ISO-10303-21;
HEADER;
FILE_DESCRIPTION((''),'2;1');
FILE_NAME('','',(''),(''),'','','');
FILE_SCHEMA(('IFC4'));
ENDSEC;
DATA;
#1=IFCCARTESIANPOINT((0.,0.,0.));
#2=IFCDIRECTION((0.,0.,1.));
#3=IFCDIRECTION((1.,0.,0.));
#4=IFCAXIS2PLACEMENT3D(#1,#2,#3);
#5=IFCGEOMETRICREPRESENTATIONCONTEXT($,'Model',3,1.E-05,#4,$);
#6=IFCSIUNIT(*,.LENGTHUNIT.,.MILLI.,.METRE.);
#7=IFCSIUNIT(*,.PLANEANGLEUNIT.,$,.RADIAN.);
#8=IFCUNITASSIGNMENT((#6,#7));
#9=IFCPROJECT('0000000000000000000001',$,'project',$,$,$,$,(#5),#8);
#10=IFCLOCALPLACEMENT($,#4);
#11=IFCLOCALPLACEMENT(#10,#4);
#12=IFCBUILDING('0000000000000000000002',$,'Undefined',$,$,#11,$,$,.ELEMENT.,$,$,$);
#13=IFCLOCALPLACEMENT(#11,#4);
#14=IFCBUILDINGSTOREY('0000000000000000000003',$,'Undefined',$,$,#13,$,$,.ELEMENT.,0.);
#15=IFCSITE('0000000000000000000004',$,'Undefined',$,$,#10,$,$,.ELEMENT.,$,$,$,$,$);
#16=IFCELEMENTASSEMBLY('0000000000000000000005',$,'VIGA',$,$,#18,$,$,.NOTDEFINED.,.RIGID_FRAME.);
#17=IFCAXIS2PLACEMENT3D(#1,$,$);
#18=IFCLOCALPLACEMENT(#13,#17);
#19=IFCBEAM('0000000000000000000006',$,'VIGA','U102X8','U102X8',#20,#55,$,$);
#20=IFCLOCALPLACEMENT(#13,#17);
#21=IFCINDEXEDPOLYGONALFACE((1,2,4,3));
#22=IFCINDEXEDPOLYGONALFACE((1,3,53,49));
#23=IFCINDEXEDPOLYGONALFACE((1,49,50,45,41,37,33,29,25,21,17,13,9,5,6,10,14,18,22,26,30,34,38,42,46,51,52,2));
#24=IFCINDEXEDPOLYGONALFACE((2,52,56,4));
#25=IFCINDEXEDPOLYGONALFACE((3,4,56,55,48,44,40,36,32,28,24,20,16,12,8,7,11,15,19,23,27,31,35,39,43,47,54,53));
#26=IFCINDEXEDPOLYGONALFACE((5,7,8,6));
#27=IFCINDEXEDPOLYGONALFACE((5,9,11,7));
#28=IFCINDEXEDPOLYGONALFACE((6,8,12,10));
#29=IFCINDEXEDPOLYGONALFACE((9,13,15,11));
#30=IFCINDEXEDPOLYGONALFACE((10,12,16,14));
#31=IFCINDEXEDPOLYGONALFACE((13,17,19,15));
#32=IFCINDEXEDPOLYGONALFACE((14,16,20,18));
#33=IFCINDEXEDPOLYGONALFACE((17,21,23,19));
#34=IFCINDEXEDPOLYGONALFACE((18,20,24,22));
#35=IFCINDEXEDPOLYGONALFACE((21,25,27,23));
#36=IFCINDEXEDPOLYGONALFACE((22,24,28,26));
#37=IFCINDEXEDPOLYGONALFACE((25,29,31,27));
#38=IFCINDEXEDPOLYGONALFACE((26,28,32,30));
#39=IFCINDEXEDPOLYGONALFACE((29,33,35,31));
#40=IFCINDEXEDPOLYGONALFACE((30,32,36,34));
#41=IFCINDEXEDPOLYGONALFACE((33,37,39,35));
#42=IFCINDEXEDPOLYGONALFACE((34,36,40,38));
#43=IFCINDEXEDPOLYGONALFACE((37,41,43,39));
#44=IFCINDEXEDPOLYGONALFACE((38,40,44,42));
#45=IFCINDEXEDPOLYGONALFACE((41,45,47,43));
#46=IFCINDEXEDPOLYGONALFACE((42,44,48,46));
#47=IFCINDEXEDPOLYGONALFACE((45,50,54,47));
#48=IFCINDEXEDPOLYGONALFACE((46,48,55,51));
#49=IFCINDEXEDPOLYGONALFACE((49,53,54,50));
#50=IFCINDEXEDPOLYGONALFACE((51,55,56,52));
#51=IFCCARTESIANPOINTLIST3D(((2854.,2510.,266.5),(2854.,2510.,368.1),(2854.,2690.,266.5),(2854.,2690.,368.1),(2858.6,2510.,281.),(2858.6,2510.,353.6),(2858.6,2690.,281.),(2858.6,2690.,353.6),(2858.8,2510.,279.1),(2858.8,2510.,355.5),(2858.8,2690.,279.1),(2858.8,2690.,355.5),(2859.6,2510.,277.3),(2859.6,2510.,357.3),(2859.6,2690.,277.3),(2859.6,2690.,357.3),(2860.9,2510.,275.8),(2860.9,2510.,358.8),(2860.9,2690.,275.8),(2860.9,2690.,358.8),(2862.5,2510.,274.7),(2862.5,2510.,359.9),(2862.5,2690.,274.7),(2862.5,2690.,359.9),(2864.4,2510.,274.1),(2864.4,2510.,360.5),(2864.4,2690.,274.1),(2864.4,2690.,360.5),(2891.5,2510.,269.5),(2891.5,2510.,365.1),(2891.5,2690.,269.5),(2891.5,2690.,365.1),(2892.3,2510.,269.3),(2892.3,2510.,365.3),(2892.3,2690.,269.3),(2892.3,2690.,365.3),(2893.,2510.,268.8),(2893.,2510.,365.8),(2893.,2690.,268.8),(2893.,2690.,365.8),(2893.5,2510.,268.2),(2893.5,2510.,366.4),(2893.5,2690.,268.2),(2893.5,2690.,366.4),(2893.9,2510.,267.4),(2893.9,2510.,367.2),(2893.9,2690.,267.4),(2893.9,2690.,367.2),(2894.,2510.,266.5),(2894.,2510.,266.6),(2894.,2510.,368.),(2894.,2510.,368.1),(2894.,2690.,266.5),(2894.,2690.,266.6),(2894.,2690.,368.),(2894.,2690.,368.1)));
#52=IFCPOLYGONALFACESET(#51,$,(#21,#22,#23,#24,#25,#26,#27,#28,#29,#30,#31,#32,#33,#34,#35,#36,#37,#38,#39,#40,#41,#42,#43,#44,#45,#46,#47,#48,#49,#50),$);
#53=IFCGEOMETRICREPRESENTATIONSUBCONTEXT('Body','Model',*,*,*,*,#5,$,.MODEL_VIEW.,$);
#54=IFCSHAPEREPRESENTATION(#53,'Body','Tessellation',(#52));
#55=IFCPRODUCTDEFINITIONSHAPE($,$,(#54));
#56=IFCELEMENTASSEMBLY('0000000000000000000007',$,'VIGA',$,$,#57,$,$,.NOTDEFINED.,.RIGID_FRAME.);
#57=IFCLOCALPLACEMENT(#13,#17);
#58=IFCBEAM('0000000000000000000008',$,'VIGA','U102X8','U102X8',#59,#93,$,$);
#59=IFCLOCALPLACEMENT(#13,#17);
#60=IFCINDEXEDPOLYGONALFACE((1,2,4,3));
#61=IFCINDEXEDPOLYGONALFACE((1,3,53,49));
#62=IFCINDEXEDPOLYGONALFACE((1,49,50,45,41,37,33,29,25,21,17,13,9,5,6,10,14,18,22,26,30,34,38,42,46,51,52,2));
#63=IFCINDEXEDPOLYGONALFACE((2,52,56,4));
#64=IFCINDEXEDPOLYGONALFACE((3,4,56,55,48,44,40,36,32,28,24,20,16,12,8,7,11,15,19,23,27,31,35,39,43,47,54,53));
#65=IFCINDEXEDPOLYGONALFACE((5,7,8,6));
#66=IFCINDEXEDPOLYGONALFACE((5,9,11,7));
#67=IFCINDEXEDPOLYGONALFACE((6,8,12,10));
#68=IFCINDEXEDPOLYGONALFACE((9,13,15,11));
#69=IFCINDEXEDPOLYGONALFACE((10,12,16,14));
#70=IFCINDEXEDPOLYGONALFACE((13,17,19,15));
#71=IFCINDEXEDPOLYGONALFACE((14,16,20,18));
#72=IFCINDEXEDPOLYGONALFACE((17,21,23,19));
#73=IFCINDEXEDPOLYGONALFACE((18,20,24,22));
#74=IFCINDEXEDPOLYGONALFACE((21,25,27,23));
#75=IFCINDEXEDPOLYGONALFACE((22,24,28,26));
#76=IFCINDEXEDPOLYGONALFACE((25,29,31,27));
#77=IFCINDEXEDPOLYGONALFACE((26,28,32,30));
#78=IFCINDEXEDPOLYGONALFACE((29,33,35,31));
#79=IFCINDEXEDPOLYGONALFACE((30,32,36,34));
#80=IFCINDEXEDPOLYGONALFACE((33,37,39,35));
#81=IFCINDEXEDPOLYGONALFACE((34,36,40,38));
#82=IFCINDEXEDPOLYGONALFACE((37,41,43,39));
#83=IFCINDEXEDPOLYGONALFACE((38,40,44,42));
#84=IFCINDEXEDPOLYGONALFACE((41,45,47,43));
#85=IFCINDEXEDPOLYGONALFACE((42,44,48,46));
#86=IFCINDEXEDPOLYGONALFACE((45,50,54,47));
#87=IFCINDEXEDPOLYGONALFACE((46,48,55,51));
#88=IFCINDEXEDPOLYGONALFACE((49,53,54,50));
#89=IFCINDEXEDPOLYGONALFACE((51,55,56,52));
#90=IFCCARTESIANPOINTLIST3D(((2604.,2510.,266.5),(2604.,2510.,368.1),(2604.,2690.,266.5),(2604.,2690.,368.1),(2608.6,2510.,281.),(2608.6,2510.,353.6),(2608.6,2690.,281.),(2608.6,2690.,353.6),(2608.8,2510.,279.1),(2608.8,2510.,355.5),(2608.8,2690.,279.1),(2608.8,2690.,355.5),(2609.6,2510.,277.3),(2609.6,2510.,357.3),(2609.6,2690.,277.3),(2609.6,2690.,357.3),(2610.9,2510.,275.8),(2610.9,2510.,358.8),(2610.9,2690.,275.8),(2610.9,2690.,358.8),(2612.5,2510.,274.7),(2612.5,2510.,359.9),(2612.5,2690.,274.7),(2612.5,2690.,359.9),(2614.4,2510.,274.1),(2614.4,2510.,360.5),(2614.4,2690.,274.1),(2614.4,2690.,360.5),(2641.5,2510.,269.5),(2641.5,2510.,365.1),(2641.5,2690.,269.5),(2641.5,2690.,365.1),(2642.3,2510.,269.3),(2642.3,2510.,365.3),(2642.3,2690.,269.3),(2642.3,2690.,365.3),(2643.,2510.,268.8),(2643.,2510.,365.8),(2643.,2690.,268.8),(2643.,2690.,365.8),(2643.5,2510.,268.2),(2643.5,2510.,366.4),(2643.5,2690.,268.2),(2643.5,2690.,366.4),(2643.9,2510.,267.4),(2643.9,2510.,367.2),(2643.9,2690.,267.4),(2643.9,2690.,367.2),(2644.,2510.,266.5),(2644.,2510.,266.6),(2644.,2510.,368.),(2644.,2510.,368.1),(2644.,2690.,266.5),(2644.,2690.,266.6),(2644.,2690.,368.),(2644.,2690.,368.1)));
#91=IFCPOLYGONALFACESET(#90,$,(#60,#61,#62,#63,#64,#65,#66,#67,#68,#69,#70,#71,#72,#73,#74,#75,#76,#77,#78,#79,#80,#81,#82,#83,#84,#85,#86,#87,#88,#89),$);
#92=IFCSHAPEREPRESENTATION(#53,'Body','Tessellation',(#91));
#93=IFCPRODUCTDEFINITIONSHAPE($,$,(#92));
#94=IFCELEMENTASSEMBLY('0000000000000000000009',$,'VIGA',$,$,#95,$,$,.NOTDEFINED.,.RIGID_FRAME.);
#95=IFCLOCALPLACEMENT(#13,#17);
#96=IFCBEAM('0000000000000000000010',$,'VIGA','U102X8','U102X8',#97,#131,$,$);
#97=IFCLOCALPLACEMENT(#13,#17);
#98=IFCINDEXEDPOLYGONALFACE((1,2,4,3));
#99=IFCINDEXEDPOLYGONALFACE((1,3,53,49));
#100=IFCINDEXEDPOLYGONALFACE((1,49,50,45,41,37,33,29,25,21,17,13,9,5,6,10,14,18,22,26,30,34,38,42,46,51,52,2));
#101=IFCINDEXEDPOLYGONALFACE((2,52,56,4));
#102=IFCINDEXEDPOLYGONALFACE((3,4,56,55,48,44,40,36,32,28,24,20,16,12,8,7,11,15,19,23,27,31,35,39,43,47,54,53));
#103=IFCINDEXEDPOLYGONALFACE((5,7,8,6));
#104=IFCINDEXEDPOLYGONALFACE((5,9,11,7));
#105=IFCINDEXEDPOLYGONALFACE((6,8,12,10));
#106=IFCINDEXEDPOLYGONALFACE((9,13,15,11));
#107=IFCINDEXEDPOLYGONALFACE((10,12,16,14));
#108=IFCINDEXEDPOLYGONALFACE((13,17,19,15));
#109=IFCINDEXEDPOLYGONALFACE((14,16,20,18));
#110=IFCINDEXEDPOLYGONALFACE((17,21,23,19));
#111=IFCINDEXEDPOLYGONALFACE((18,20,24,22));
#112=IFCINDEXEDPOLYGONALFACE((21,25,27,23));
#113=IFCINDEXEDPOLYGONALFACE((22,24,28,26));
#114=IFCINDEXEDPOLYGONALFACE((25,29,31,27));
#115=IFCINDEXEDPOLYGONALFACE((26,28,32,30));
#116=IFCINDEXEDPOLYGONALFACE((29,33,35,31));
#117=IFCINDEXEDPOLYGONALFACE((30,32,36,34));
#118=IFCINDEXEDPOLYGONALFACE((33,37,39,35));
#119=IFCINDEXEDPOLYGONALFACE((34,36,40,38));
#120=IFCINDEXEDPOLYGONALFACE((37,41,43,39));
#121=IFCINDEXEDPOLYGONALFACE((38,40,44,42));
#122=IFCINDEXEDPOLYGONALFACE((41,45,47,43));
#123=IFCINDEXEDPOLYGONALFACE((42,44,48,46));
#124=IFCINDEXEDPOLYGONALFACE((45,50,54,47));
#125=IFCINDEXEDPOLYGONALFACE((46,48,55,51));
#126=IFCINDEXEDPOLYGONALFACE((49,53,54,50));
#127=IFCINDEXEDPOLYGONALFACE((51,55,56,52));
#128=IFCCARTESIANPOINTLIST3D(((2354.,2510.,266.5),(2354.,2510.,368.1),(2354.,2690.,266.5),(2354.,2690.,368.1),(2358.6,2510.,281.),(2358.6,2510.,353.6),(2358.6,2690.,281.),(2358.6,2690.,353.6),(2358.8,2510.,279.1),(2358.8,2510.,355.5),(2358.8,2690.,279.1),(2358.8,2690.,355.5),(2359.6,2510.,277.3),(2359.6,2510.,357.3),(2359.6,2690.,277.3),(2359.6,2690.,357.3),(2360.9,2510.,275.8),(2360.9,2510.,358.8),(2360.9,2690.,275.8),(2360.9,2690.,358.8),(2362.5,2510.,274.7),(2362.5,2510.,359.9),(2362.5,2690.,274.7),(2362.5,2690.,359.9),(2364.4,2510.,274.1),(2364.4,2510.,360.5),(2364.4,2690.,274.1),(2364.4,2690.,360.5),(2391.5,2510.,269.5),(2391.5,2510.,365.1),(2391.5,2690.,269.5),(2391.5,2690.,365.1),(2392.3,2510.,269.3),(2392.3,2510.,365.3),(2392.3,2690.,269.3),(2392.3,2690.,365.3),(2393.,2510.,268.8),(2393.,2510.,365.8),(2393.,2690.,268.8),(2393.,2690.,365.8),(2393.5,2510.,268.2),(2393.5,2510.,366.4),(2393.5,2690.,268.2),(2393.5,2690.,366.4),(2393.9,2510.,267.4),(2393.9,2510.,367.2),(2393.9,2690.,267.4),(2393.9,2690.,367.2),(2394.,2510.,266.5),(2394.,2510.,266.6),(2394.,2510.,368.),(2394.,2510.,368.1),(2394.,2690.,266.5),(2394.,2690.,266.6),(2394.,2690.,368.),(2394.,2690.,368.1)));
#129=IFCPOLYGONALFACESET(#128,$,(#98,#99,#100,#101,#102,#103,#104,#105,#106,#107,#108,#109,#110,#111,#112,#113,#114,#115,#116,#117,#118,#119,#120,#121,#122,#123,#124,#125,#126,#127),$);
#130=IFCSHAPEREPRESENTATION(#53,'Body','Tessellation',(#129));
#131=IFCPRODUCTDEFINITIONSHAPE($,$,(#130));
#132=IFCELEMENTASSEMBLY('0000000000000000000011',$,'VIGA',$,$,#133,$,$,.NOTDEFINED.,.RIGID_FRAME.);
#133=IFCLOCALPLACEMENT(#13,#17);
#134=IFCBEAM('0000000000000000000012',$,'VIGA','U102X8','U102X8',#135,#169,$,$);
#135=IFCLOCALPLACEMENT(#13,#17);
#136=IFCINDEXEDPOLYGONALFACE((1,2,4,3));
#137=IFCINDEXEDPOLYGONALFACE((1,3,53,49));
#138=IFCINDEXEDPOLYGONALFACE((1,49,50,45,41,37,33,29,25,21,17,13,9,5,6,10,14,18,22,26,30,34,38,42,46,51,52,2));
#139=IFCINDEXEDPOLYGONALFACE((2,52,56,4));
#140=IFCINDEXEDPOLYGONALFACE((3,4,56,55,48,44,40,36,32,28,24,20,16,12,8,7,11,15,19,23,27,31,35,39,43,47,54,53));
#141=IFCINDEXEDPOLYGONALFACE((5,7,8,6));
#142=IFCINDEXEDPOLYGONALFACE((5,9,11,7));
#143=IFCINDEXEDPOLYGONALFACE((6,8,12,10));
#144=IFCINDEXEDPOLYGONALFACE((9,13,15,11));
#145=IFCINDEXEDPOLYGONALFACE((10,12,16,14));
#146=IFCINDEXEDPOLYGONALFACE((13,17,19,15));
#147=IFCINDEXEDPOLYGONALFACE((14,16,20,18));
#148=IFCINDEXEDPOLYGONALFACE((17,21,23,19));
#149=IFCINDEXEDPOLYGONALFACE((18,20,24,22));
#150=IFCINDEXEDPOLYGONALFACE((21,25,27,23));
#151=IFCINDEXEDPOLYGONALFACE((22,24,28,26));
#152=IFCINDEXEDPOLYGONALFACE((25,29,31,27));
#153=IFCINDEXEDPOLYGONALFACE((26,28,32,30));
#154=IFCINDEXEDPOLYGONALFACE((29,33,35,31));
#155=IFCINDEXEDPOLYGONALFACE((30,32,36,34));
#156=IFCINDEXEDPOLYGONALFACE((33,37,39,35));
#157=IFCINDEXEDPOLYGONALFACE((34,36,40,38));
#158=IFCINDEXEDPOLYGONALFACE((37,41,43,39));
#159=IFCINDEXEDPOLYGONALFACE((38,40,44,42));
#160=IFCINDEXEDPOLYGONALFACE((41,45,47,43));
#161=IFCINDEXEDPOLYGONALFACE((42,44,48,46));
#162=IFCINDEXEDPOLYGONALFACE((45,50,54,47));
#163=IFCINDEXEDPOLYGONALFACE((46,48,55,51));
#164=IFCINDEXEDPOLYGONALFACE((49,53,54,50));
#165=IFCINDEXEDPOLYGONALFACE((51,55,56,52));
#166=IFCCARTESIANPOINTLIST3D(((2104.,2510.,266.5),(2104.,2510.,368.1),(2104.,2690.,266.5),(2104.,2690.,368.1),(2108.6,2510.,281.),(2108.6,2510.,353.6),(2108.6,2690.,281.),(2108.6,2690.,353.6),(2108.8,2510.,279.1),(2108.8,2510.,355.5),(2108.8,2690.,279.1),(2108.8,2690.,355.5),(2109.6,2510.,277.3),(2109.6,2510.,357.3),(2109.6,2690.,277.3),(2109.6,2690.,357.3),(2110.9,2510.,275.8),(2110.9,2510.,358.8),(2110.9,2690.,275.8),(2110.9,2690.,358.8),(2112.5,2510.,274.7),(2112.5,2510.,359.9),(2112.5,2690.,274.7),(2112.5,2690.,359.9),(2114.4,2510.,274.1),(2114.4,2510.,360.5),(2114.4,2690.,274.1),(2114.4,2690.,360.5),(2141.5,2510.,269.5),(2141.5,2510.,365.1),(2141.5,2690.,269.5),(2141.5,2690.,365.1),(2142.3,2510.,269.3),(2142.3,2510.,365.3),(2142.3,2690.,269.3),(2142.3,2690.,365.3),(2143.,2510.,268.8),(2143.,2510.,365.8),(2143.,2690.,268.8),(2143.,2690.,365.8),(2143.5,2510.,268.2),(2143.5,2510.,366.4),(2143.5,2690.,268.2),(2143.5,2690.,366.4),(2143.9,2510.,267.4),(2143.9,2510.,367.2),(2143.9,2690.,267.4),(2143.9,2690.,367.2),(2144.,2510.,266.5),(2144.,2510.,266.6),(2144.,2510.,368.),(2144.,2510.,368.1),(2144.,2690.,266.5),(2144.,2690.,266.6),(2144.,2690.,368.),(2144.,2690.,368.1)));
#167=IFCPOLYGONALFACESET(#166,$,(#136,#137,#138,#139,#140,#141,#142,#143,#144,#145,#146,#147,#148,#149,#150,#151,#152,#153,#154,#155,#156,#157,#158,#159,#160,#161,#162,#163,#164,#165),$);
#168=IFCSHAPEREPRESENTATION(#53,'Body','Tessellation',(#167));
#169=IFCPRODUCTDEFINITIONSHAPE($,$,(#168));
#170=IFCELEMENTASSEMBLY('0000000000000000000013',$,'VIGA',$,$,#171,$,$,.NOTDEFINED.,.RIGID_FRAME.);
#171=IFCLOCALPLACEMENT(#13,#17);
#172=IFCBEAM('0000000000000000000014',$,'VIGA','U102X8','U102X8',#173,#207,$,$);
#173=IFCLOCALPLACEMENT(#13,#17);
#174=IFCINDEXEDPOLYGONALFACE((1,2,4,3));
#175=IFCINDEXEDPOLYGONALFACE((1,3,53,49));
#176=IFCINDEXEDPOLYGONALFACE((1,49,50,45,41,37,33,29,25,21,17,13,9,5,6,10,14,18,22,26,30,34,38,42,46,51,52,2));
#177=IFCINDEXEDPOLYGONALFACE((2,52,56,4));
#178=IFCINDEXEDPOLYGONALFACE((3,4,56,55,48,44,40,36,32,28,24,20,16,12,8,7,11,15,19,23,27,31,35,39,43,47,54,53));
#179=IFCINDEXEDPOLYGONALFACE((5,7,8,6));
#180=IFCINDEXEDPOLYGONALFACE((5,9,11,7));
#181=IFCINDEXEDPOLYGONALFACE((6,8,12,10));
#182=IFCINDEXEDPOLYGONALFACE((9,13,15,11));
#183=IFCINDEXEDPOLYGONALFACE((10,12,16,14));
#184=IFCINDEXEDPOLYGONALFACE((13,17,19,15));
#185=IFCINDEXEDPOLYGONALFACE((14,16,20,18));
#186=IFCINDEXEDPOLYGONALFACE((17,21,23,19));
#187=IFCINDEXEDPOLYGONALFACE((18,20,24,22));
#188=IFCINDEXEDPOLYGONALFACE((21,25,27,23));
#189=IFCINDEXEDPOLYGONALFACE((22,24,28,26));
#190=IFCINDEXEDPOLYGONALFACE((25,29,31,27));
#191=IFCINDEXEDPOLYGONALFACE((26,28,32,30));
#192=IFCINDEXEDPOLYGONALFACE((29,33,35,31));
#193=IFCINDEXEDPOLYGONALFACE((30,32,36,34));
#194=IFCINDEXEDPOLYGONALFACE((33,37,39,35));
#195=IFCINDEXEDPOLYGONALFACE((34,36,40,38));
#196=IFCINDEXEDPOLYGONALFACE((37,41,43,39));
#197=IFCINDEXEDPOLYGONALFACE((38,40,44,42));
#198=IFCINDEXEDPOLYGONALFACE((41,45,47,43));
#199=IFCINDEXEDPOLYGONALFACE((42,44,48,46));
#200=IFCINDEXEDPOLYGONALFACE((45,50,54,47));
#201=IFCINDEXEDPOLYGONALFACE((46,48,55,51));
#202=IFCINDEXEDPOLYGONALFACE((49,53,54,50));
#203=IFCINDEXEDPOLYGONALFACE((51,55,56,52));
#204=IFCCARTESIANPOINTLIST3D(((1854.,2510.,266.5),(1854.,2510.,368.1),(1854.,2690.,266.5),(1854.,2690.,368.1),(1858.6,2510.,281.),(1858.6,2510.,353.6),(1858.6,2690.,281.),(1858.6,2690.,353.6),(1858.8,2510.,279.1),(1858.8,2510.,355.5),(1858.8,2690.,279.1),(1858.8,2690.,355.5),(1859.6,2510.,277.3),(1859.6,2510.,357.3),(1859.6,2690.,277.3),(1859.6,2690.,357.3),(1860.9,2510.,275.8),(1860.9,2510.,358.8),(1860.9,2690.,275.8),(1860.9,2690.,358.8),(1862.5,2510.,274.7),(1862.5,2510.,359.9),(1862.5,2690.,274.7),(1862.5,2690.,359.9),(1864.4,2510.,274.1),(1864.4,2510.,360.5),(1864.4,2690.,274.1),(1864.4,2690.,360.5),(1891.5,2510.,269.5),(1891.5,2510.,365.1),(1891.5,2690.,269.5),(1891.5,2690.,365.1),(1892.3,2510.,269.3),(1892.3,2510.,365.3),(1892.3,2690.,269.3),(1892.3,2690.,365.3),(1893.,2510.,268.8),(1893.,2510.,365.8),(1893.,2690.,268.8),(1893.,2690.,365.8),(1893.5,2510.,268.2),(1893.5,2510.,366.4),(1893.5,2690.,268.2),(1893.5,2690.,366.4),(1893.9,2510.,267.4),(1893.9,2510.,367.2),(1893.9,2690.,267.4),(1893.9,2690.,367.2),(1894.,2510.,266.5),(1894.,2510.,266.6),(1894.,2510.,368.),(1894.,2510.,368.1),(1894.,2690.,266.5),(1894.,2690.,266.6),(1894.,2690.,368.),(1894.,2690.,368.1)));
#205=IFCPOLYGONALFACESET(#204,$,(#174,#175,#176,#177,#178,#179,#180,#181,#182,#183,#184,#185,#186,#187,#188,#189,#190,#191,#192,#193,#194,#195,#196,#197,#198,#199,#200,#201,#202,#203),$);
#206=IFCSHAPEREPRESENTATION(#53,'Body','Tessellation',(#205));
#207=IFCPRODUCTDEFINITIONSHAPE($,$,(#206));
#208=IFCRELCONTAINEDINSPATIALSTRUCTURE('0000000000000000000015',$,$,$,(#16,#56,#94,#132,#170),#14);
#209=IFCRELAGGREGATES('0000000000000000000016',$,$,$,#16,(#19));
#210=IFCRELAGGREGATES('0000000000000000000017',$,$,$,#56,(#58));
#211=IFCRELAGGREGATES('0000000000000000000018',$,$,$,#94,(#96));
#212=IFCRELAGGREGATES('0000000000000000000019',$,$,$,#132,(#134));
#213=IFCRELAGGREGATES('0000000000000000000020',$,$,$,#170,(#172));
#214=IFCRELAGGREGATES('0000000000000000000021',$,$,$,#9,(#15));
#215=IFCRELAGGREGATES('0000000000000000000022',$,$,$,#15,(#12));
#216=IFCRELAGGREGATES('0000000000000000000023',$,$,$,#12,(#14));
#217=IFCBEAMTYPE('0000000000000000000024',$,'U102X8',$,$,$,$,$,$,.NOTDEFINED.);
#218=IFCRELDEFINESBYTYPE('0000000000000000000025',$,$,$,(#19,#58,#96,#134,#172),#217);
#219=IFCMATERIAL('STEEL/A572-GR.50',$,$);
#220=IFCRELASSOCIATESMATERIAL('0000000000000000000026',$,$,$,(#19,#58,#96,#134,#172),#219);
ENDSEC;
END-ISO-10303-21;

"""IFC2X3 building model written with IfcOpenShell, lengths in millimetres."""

from ifc_helpers import new_model, si_unit, frame, origin_with_axes, origin_2d_with_axis, place, context, subcontext, project, spatial, u_section, extrude, material, type_object, element, aggregate, save


model = new_model("IFC2X3")

# Units and contexts
model_context = context("Model", 3, precision=1e-05, world=origin_with_axes())
body_context = subcontext(model_context, "Body", "Model", "MODEL_VIEW")
ifc_project = project(units=[si_unit("LENGTHUNIT", "METRE", prefix="MILLI"), si_unit("PLANEANGLEUNIT", "RADIAN")], contexts=[model_context])

# Site, building, storey
site_placement = place(None, origin_with_axes())
site = spatial("IfcSite", under=ifc_project, at=site_placement, Name="Undefined", CompositionType="ELEMENT")
building_placement = place(site_placement, origin_with_axes())
building = spatial("IfcBuilding", under=site, at=building_placement, Name="Undefined", CompositionType="ELEMENT")
storey_placement = place(building_placement, origin_with_axes())
storey = spatial("IfcBuildingStorey", under=building, at=storey_placement, Name="Undefined", CompositionType="ELEMENT", Elevation=0.0)

# Element assemblies, beams
ifc_material_1 = material(Name="STEEL/A572-GR.50")
beam_type_1 = type_object("IfcBeamType", Name="U102X8", PredefinedType="NOTDEFINED")
assembly_1_placement = place(storey_placement, origin_with_axes())
assembly_1 = element("IfcElementAssembly", 1, at=assembly_1_placement, inside=storey, Name="VIGA", AssemblyPlace="NOTDEFINED", PredefinedType="RIGID_FRAME")
beam_1_placement = place(assembly_1_placement, frame((2874.0, 2510.0, 317.3), z_axis=(0.0, 0.0, 1.0), x_axis=(0.0, 1.0, 0.0)))
beam_1 = element("IfcBeam", 2, at=beam_1_placement, type_object=beam_type_1, material=ifc_material_1, Name="VIGA", Description="U102X8", ObjectType="U102X8", context=body_context, shape_type="SweptSolid", body=[
    extrude(u_section(Depth=101.6, FlangeWidth=40.0, WebThickness=4.6, FlangeThickness=6.0, FilletRadius=7.0, EdgeRadius=3.0, FlangeSlope=0.16839, at=origin_2d_with_axis()), frame((180.0, 0.0, 0.0), z_axis=(-1.0, 0.0, 0.0), x_axis=(0.0, -1.0, 0.0)), (0.0, 0.0, 1.0), 180.0),
])
aggregate(assembly_1, [beam_1])
assembly_2_placement = place(storey_placement, origin_with_axes())
assembly_2 = element("IfcElementAssembly", 3, at=assembly_2_placement, inside=storey, Name="VIGA", AssemblyPlace="NOTDEFINED", PredefinedType="RIGID_FRAME")
beam_2_placement = place(assembly_2_placement, frame((2624.0, 2510.0, 317.3), z_axis=(0.0, 0.0, 1.0), x_axis=(0.0, 1.0, 0.0)))
beam_2 = element("IfcBeam", 4, at=beam_2_placement, type_object=beam_type_1, material=ifc_material_1, Name="VIGA", Description="U102X8", ObjectType="U102X8", context=body_context, shape_type="SweptSolid", body=[
    extrude(u_section(Depth=101.6, FlangeWidth=40.0, WebThickness=4.6, FlangeThickness=6.0, FilletRadius=7.0, EdgeRadius=3.0, FlangeSlope=0.16839, at=origin_2d_with_axis()), frame((180.0, 0.0, 0.0), z_axis=(-1.0, 0.0, 0.0), x_axis=(0.0, -1.0, 0.0)), (0.0, 0.0, 1.0), 180.0),
])
aggregate(assembly_2, [beam_2])
assembly_3_placement = place(storey_placement, origin_with_axes())
assembly_3 = element("IfcElementAssembly", 5, at=assembly_3_placement, inside=storey, Name="VIGA", AssemblyPlace="NOTDEFINED", PredefinedType="RIGID_FRAME")
beam_3_placement = place(assembly_3_placement, frame((2374.0, 2510.0, 317.3), z_axis=(0.0, 0.0, 1.0), x_axis=(0.0, 1.0, 0.0)))
beam_3 = element("IfcBeam", 6, at=beam_3_placement, type_object=beam_type_1, material=ifc_material_1, Name="VIGA", Description="U102X8", ObjectType="U102X8", context=body_context, shape_type="SweptSolid", body=[
    extrude(u_section(Depth=101.6, FlangeWidth=40.0, WebThickness=4.6, FlangeThickness=6.0, FilletRadius=7.0, EdgeRadius=3.0, FlangeSlope=0.16839, at=origin_2d_with_axis()), frame((180.0, 0.0, 0.0), z_axis=(-1.0, 0.0, 0.0), x_axis=(0.0, -1.0, 0.0)), (0.0, 0.0, 1.0), 180.0),
])
aggregate(assembly_3, [beam_3])
assembly_4_placement = place(storey_placement, origin_with_axes())
assembly_4 = element("IfcElementAssembly", 7, at=assembly_4_placement, inside=storey, Name="VIGA", AssemblyPlace="NOTDEFINED", PredefinedType="RIGID_FRAME")
beam_4_placement = place(assembly_4_placement, frame((2124.0, 2510.0, 317.3), z_axis=(0.0, 0.0, 1.0), x_axis=(0.0, 1.0, 0.0)))
beam_4 = element("IfcBeam", 8, at=beam_4_placement, type_object=beam_type_1, material=ifc_material_1, Name="VIGA", Description="U102X8", ObjectType="U102X8", context=body_context, shape_type="SweptSolid", body=[
    extrude(u_section(Depth=101.6, FlangeWidth=40.0, WebThickness=4.6, FlangeThickness=6.0, FilletRadius=7.0, EdgeRadius=3.0, FlangeSlope=0.16839, at=origin_2d_with_axis()), frame((180.0, 0.0, 0.0), z_axis=(-1.0, 0.0, 0.0), x_axis=(0.0, -1.0, 0.0)), (0.0, 0.0, 1.0), 180.0),
])
aggregate(assembly_4, [beam_4])
assembly_5_placement = place(storey_placement, origin_with_axes())
assembly_5 = element("IfcElementAssembly", 9, at=assembly_5_placement, inside=storey, Name="VIGA", AssemblyPlace="NOTDEFINED", PredefinedType="RIGID_FRAME")
beam_5_placement = place(assembly_5_placement, frame((1874.0, 2510.0, 317.3), z_axis=(0.0, 0.0, 1.0), x_axis=(0.0, 1.0, 0.0)))
beam_5 = element("IfcBeam", 10, at=beam_5_placement, type_object=beam_type_1, material=ifc_material_1, Name="VIGA", Description="U102X8", ObjectType="U102X8", context=body_context, shape_type="SweptSolid", body=[
    extrude(u_section(Depth=101.6, FlangeWidth=40.0, WebThickness=4.6, FlangeThickness=6.0, FilletRadius=7.0, EdgeRadius=3.0, FlangeSlope=0.16839, at=origin_2d_with_axis()), frame((180.0, 0.0, 0.0), z_axis=(-1.0, 0.0, 0.0), x_axis=(0.0, -1.0, 0.0)), (0.0, 0.0, 1.0), 180.0),
])
aggregate(assembly_5, [beam_5])

save(model, "model.ifc")
